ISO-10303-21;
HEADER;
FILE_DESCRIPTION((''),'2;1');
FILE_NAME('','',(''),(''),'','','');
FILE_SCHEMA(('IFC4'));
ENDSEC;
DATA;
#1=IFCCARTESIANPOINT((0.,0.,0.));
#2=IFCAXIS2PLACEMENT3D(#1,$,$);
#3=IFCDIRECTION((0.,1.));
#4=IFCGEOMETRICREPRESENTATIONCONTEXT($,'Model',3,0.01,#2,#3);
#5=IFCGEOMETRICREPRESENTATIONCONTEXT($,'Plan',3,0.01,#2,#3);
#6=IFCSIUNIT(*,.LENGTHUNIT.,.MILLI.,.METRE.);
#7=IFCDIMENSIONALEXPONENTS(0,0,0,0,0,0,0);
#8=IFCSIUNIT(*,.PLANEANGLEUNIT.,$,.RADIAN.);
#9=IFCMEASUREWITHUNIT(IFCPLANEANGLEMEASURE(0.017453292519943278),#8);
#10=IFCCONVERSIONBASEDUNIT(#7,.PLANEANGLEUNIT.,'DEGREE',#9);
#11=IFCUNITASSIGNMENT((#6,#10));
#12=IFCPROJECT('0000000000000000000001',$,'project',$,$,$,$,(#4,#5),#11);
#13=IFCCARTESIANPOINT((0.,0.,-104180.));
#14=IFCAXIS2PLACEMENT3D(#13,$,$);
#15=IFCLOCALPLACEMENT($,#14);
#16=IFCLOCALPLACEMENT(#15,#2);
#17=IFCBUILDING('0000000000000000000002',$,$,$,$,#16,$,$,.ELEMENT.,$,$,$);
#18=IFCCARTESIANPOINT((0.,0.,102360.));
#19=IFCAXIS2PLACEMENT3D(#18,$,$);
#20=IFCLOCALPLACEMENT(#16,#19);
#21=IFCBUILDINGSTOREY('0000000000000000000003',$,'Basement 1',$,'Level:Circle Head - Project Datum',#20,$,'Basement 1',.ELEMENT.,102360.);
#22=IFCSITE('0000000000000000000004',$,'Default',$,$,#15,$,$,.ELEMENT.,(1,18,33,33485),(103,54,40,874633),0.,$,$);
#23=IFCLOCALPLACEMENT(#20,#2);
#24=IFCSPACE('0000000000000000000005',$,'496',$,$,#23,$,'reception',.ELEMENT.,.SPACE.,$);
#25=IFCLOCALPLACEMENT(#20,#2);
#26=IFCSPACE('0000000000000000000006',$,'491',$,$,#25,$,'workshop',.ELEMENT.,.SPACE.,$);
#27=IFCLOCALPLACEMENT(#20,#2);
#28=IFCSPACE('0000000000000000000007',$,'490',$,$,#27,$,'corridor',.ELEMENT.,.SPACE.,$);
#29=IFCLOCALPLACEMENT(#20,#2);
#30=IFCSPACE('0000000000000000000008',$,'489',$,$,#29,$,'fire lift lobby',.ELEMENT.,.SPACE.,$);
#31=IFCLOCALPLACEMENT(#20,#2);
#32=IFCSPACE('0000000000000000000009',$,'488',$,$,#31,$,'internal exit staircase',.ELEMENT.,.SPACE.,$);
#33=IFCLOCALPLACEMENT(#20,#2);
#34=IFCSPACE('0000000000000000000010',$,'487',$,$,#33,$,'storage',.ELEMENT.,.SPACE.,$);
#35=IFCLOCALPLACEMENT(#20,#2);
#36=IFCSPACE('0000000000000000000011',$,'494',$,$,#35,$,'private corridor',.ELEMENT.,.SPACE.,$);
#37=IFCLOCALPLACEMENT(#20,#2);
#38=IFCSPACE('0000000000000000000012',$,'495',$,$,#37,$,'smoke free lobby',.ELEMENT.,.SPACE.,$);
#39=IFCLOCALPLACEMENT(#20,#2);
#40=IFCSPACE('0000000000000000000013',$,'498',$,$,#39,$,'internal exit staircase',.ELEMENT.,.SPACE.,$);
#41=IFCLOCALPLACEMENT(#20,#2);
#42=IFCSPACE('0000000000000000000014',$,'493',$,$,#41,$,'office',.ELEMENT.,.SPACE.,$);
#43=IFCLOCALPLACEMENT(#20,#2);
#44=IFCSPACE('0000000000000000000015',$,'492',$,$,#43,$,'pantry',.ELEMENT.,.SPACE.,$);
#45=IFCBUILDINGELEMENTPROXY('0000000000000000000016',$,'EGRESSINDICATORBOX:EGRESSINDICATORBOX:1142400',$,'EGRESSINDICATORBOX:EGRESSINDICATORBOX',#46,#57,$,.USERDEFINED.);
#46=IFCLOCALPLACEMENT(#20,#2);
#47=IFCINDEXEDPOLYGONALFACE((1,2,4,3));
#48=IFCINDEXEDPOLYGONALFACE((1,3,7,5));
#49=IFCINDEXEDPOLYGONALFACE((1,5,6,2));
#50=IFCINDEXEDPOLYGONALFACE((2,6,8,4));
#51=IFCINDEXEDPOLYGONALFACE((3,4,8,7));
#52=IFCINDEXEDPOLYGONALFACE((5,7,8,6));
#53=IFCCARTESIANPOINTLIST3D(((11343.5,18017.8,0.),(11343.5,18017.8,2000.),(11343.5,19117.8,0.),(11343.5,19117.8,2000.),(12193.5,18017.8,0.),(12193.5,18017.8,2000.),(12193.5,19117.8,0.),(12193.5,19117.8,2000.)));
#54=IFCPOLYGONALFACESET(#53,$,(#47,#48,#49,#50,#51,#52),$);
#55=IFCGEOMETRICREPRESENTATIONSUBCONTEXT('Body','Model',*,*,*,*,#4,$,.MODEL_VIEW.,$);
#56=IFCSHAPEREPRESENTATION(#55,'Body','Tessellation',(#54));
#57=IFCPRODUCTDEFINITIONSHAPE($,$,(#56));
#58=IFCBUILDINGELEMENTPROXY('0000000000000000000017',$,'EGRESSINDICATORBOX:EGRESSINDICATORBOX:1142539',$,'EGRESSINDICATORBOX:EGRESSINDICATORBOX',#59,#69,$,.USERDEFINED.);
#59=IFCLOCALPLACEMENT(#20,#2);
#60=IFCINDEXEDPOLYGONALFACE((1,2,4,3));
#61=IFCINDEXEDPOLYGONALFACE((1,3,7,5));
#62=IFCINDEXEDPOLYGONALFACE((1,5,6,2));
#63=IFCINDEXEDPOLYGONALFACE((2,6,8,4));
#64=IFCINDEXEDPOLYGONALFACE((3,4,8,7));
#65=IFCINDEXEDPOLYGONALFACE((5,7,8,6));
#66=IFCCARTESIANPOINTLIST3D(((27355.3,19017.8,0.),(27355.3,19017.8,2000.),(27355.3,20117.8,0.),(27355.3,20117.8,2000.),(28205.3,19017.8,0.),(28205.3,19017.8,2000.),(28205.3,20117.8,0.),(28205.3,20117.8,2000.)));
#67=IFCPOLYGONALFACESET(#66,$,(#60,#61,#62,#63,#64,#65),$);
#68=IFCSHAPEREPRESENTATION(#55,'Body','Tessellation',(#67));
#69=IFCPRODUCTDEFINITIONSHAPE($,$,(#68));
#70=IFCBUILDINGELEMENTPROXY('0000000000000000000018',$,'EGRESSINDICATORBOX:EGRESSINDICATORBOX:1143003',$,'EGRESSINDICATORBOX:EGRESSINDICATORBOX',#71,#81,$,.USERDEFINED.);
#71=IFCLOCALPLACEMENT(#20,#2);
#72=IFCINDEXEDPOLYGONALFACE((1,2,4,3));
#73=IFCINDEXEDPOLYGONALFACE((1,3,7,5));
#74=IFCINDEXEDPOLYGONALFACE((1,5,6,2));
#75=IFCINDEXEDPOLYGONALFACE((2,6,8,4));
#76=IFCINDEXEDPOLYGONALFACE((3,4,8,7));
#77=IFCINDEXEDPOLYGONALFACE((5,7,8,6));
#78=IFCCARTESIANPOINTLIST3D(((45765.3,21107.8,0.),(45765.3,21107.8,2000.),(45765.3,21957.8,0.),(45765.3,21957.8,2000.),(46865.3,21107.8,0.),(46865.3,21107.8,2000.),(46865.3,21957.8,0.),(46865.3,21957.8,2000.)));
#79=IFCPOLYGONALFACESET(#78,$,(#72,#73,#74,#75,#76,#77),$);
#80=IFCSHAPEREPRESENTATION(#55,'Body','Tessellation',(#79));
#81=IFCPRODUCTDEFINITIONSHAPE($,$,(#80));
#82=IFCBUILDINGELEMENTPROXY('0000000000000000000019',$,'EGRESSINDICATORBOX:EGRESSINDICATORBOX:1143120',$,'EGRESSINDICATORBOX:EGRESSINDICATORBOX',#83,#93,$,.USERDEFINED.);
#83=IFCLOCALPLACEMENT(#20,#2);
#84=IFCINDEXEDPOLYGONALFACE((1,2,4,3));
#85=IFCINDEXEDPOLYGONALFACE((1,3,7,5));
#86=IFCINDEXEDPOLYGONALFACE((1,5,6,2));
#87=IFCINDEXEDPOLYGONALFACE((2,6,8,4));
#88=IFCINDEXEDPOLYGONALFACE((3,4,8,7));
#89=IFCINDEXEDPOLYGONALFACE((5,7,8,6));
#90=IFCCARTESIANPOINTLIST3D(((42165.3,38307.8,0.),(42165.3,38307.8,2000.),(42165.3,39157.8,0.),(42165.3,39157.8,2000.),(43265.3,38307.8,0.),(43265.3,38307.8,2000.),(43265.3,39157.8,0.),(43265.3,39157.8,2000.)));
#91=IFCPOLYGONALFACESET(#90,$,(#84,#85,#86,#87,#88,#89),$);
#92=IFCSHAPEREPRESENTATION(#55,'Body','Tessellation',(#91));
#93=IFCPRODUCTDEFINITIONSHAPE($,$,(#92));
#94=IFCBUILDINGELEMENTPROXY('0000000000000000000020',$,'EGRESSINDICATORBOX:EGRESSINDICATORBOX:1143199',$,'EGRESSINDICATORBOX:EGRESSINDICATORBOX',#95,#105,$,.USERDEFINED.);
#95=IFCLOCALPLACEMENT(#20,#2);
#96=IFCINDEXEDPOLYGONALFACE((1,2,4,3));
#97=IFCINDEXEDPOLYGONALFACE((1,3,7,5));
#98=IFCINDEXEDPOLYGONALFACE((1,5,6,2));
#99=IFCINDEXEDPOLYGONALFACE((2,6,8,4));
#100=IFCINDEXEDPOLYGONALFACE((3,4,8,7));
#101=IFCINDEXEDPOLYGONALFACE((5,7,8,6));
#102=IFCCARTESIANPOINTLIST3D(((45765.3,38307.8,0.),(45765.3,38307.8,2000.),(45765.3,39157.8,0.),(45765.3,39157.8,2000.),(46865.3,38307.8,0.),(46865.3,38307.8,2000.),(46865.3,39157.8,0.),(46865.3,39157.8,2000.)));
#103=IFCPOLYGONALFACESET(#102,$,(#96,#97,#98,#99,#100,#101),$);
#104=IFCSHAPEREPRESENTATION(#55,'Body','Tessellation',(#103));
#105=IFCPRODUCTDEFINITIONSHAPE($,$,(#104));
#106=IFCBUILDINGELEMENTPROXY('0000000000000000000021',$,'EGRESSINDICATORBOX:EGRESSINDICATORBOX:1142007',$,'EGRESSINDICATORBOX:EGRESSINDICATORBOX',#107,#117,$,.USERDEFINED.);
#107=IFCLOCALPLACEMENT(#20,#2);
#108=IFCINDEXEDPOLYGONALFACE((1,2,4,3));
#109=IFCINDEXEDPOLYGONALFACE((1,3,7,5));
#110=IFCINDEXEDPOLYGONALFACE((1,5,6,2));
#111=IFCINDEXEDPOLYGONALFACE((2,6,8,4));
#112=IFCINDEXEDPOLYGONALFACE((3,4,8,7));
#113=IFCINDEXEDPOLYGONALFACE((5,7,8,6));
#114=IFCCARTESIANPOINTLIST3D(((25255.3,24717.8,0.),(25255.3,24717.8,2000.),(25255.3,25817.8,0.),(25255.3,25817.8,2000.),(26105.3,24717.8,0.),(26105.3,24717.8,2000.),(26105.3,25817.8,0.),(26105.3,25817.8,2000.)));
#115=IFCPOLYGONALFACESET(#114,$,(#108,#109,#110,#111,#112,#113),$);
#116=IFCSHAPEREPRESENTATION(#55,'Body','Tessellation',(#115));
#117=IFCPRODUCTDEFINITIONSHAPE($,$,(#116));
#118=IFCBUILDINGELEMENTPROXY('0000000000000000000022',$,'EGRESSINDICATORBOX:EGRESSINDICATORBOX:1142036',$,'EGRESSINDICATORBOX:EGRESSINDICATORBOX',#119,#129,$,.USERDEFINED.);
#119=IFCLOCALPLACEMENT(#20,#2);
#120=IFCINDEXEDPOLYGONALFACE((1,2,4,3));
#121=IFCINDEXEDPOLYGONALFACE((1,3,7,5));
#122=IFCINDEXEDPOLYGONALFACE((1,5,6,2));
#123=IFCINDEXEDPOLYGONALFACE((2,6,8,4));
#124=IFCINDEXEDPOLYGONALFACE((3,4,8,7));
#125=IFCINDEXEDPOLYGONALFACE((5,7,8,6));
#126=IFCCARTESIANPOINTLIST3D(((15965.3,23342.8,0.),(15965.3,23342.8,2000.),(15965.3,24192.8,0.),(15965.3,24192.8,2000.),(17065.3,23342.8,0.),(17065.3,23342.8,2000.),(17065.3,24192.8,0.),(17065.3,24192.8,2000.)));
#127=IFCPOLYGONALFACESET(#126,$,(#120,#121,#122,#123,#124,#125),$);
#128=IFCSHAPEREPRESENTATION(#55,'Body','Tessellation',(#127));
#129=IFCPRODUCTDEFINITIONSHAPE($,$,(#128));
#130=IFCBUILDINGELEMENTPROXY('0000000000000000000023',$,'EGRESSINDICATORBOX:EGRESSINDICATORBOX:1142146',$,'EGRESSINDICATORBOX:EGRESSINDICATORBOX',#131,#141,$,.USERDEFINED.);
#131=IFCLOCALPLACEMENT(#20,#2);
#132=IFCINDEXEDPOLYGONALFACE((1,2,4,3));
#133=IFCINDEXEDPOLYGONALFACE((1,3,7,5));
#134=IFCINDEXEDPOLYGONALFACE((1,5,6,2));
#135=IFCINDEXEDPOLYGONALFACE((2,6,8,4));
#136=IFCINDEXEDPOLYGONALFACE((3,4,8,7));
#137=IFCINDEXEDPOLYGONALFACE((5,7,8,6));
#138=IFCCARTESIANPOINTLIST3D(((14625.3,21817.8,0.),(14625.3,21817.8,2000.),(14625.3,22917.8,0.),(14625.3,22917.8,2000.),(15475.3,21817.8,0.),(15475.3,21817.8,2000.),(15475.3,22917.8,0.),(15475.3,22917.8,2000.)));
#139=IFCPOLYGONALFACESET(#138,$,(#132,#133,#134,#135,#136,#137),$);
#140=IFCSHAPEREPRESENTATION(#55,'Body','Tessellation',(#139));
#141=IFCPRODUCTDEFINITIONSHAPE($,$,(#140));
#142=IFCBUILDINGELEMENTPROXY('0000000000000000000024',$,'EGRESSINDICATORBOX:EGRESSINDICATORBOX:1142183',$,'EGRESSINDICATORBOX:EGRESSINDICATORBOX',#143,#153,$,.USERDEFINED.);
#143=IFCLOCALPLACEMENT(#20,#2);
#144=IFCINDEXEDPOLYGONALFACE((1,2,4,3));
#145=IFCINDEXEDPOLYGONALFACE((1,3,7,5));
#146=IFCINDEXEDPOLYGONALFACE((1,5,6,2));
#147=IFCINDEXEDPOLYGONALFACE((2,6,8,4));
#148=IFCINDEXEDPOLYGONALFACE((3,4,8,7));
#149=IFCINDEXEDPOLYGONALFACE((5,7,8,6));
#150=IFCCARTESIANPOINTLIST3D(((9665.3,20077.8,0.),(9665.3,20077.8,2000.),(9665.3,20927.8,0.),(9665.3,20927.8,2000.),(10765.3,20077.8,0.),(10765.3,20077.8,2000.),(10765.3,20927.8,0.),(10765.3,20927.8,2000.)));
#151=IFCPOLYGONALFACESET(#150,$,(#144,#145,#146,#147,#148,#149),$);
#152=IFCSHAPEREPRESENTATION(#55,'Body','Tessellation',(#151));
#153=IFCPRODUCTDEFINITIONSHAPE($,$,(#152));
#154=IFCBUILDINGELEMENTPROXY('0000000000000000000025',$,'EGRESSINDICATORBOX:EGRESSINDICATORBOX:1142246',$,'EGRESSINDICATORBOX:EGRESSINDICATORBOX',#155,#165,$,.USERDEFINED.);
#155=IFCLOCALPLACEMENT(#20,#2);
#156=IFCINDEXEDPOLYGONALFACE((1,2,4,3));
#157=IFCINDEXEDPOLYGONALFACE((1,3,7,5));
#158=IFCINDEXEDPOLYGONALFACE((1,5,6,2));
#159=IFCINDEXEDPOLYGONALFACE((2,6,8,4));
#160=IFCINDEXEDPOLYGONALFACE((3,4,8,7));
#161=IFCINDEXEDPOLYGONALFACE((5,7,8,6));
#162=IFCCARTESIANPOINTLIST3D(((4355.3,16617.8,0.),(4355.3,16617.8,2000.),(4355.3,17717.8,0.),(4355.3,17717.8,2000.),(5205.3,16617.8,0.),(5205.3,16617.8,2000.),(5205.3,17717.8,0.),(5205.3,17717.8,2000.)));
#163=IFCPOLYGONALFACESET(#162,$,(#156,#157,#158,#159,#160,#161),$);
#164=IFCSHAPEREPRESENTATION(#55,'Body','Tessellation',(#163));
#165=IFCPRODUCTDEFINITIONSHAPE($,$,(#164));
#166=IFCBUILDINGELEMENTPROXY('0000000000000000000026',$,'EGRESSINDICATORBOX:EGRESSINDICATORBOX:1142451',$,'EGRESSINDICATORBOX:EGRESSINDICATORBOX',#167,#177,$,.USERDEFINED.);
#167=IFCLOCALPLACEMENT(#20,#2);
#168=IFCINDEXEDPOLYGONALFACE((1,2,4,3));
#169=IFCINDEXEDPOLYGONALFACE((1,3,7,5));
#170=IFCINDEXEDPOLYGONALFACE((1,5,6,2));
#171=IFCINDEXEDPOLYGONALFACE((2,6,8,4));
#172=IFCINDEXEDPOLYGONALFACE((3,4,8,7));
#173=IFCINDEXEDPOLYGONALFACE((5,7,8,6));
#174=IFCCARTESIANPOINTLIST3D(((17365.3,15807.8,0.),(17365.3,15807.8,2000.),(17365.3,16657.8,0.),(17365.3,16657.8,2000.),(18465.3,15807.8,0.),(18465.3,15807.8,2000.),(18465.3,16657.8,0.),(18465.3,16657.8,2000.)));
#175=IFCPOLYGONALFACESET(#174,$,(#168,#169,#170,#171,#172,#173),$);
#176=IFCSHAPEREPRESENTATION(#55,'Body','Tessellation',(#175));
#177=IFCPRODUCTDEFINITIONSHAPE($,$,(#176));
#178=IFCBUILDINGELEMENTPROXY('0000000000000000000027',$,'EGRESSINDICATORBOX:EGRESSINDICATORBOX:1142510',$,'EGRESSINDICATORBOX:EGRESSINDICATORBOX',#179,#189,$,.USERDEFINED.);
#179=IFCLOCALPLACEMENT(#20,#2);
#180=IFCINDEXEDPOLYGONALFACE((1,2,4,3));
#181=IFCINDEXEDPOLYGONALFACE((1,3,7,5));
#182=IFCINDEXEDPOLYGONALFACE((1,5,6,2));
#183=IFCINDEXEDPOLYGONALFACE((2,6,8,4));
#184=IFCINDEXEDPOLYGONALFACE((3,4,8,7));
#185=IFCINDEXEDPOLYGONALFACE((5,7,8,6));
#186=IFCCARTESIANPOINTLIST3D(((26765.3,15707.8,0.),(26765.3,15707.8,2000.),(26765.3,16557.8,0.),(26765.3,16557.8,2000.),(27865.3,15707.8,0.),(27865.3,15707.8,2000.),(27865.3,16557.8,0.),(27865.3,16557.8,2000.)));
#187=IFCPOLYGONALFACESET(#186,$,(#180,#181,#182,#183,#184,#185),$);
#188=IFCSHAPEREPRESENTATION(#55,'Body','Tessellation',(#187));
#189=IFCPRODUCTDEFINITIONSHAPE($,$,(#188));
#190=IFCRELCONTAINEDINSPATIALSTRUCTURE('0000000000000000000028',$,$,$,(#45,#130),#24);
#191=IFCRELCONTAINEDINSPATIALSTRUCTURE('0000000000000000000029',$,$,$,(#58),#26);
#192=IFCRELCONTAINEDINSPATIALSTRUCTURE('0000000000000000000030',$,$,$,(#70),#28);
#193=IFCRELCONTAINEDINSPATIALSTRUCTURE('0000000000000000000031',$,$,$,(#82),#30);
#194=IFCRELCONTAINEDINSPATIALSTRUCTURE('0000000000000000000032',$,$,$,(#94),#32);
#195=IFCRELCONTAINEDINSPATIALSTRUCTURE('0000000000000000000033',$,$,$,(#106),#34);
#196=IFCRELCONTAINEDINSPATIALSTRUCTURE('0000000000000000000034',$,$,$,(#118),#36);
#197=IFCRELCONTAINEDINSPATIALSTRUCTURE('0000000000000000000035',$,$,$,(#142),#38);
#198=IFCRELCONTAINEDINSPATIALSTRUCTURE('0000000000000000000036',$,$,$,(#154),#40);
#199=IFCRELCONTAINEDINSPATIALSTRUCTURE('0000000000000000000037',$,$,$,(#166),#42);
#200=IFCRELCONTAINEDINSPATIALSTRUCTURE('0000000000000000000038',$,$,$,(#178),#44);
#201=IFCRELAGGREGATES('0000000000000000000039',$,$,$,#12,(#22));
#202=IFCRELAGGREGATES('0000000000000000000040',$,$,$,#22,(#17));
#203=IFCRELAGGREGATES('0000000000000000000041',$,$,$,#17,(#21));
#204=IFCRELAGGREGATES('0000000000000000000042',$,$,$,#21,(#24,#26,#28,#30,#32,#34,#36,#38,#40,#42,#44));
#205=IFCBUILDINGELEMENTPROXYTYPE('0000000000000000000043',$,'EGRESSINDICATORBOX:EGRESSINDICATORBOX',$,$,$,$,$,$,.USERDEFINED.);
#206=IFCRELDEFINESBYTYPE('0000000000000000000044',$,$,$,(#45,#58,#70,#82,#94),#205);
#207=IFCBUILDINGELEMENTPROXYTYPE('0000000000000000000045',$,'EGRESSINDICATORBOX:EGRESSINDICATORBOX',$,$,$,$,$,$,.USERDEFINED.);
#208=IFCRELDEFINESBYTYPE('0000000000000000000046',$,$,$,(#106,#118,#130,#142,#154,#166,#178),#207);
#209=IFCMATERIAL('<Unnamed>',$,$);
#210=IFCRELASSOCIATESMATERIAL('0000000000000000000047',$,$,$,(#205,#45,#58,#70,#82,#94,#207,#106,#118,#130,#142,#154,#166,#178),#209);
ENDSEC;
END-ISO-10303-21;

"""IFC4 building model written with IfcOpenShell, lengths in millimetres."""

from ifc_helpers import new_model, entity, si_unit, converted_unit, direction, frame, origin, place, context, subcontext, project, spatial, indexed_curve, outline, extrude, source, transform, mapped, material, type_object, type_shapes, element, save


model = new_model("IFC4")

# Units and contexts
model_context = context("Model", 3, precision=0.01, world=origin(), true_north=direction((0.0, 1.0)))
plan_context = context("Plan", 3, precision=0.01, world=origin(), true_north=direction((0.0, 1.0)))
body_context = subcontext(model_context, "Body", "Model", "MODEL_VIEW")
ifc_project = project(units=[si_unit("LENGTHUNIT", "METRE", prefix="MILLI"), converted_unit("PLANEANGLEUNIT", "DEGREE", entity("IfcPlaneAngleMeasure", 0.017453292519943278), si_unit("PLANEANGLEUNIT", "RADIAN"), dimensions=[0, 0, 0, 0, 0, 0, 0])], contexts=[model_context, plan_context])

# Site, building, storey
site_placement = place(None, frame((0.0, 0.0, -104180.0)))
site = spatial("IfcSite", under=ifc_project, at=site_placement, Name="Default", CompositionType="ELEMENT", RefLatitude=(1, 18, 33, 33485), RefLongitude=(103, 54, 40, 874633), RefElevation=0.0)
building_placement = place(site_placement, origin())
building = spatial("IfcBuilding", under=site, at=building_placement, CompositionType="ELEMENT")
storey_placement = place(building_placement, frame((0.0, 0.0, 102360.0)))
storey = spatial("IfcBuildingStorey", under=building, at=storey_placement, Name="Basement 1", ObjectType="Level:Circle Head - Project Datum", LongName="Basement 1", CompositionType="ELEMENT", Elevation=102360.0)

# Shared definitions
ifc_material_1 = material(Name="<Unnamed>")
building_element_proxy_type_1 = type_object("IfcBuildingElementProxyType", Name="EGRESSINDICATORBOX:EGRESSINDICATORBOX", PredefinedType="USERDEFINED", material=ifc_material_1)
shared_shape_1 = source(origin(), body_context, "Body", "SweptSolid", [
    extrude(outline(indexed_curve([(-550.0, -425.0), (550.0, -425.0), (550.0, 425.0), (-550.0, 425.0), (-550.0, -425.0)], self_intersect=False)), frame((0.0, 0.0, 0.0), z_axis=(0.0, 0.0, 1.0), x_axis=(0.0, 1.0, 0.0)), (0.0, 0.0, 1.0), 2000.0),
])
type_shapes(building_element_proxy_type_1, [shared_shape_1])

# Shared definitions
space_1_placement = place(storey_placement, origin())
space_1 = spatial("IfcSpace", under=storey, at=space_1_placement, Name="496", LongName="reception", CompositionType="ELEMENT", PredefinedType="SPACE")

# Building element proxy
proxy_1_placement = place(space_1_placement, frame((11768.5, 18567.8, 0.0), z_axis=(0.0, 0.0, 1.0), x_axis=(-1.0, 0.0, 0.0)))
element("IfcBuildingElementProxy", 1, at=proxy_1_placement, inside=space_1, type_object=building_element_proxy_type_1, material=ifc_material_1, Name="EGRESSINDICATORBOX:EGRESSINDICATORBOX:1142400", ObjectType="EGRESSINDICATORBOX:EGRESSINDICATORBOX", PredefinedType="USERDEFINED", context=body_context, shape_type="MappedRepresentation", body=[
    mapped(shared_shape_1, transform((0.0, 0.0, 0.0), scale=1.0)),
])

# Shared definitions
space_2_placement = place(storey_placement, origin())
space_2 = spatial("IfcSpace", under=storey, at=space_2_placement, Name="491", LongName="workshop", CompositionType="ELEMENT", PredefinedType="SPACE")

# Building element proxy
proxy_2_placement = place(space_2_placement, frame((27780.3, 19567.8, 0.0), z_axis=(0.0, 0.0, 1.0), x_axis=(-1.0, 0.0, 0.0)))
element("IfcBuildingElementProxy", 2, at=proxy_2_placement, inside=space_2, type_object=building_element_proxy_type_1, material=ifc_material_1, Name="EGRESSINDICATORBOX:EGRESSINDICATORBOX:1142539", ObjectType="EGRESSINDICATORBOX:EGRESSINDICATORBOX", PredefinedType="USERDEFINED", context=body_context, shape_type="MappedRepresentation", body=[
    mapped(shared_shape_1, transform((0.0, 0.0, 0.0), scale=1.0)),
])

# Shared definitions
space_3_placement = place(storey_placement, origin())
space_3 = spatial("IfcSpace", under=storey, at=space_3_placement, Name="490", LongName="corridor", CompositionType="ELEMENT", PredefinedType="SPACE")

# Building element proxy
proxy_3_placement = place(space_3_placement, frame((46315.3, 21532.8, 0.0), z_axis=(0.0, 0.0, 1.0), x_axis=(0.0, 1.0, 0.0)))
element("IfcBuildingElementProxy", 3, at=proxy_3_placement, inside=space_3, type_object=building_element_proxy_type_1, material=ifc_material_1, Name="EGRESSINDICATORBOX:EGRESSINDICATORBOX:1143003", ObjectType="EGRESSINDICATORBOX:EGRESSINDICATORBOX", PredefinedType="USERDEFINED", context=body_context, shape_type="MappedRepresentation", body=[
    mapped(shared_shape_1, transform((0.0, 0.0, 0.0), scale=1.0)),
])

# Shared definitions
space_4_placement = place(storey_placement, origin())
space_4 = spatial("IfcSpace", under=storey, at=space_4_placement, Name="489", LongName="fire lift lobby", CompositionType="ELEMENT", PredefinedType="SPACE")

# Building element proxy
proxy_4_placement = place(space_4_placement, frame((42715.3, 38732.8, 0.0), z_axis=(0.0, 0.0, 1.0), x_axis=(0.0, 1.0, 0.0)))
element("IfcBuildingElementProxy", 4, at=proxy_4_placement, inside=space_4, type_object=building_element_proxy_type_1, material=ifc_material_1, Name="EGRESSINDICATORBOX:EGRESSINDICATORBOX:1143120", ObjectType="EGRESSINDICATORBOX:EGRESSINDICATORBOX", PredefinedType="USERDEFINED", context=body_context, shape_type="MappedRepresentation", body=[
    mapped(shared_shape_1, transform((0.0, 0.0, 0.0), scale=1.0)),
])

# Shared definitions
space_5_placement = place(storey_placement, origin())
space_5 = spatial("IfcSpace", under=storey, at=space_5_placement, Name="488", LongName="internal exit staircase", CompositionType="ELEMENT", PredefinedType="SPACE")

# Building element proxy
proxy_5_placement = place(space_5_placement, frame((46315.3, 38732.8, 0.0), z_axis=(0.0, 0.0, 1.0), x_axis=(0.0, 1.0, 0.0)))
element("IfcBuildingElementProxy", 5, at=proxy_5_placement, inside=space_5, type_object=building_element_proxy_type_1, material=ifc_material_1, Name="EGRESSINDICATORBOX:EGRESSINDICATORBOX:1143199", ObjectType="EGRESSINDICATORBOX:EGRESSINDICATORBOX", PredefinedType="USERDEFINED", context=body_context, shape_type="MappedRepresentation", body=[
    mapped(shared_shape_1, transform((0.0, 0.0, 0.0), scale=1.0)),
])

# Shared definitions
space_6_placement = place(storey_placement, origin())
space_6 = spatial("IfcSpace", under=storey, at=space_6_placement, Name="487", LongName="storage", CompositionType="ELEMENT", PredefinedType="SPACE")

# Building element proxy
building_element_proxy_type_2 = type_object("IfcBuildingElementProxyType", Name="EGRESSINDICATORBOX:EGRESSINDICATORBOX", PredefinedType="USERDEFINED", material=ifc_material_1)
shared_shape_2 = source(origin(), body_context, "Body", "SweptSolid", [
    extrude(outline(indexed_curve([(-425.0, -550.0), (425.0, -550.0), (425.0, 550.0), (-425.0, 550.0), (-425.0, -550.0)], self_intersect=False)), frame((0.0, 0.0, 0.0), z_axis=(0.0, 0.0, 1.0), x_axis=(-1.0, 0.0, 0.0)), (0.0, 0.0, 1.0), 2000.0),
])
type_shapes(building_element_proxy_type_2, [shared_shape_2])
proxy_6_placement = place(space_6_placement, frame((25680.3, 25267.8, 0.0)))
element("IfcBuildingElementProxy", 6, at=proxy_6_placement, inside=space_6, type_object=building_element_proxy_type_2, material=ifc_material_1, Name="EGRESSINDICATORBOX:EGRESSINDICATORBOX:1142007", ObjectType="EGRESSINDICATORBOX:EGRESSINDICATORBOX", PredefinedType="USERDEFINED", context=body_context, shape_type="MappedRepresentation", body=[
    mapped(shared_shape_2, transform((0.0, 0.0, 0.0), scale=1.0)),
])

# Shared definitions
space_7_placement = place(storey_placement, origin())
space_7 = spatial("IfcSpace", under=storey, at=space_7_placement, Name="494", LongName="private corridor", CompositionType="ELEMENT", PredefinedType="SPACE")

# Building element proxies
proxy_7_placement = place(space_7_placement, frame((16515.3, 23767.8, 0.0), z_axis=(0.0, 0.0, 1.0), x_axis=(0.0, 1.0, 0.0)))
element("IfcBuildingElementProxy", 7, at=proxy_7_placement, inside=space_7, type_object=building_element_proxy_type_2, material=ifc_material_1, Name="EGRESSINDICATORBOX:EGRESSINDICATORBOX:1142036", ObjectType="EGRESSINDICATORBOX:EGRESSINDICATORBOX", PredefinedType="USERDEFINED", context=body_context, shape_type="MappedRepresentation", body=[
    mapped(shared_shape_2, transform((0.0, 0.0, 0.0), scale=1.0)),
])
proxy_8_placement = place(space_1_placement, frame((15050.3, 22367.8, 0.0), z_axis=(0.0, 0.0, 1.0), x_axis=(-1.0, 0.0, 0.0)))
element("IfcBuildingElementProxy", 8, at=proxy_8_placement, inside=space_1, type_object=building_element_proxy_type_2, material=ifc_material_1, Name="EGRESSINDICATORBOX:EGRESSINDICATORBOX:1142146", ObjectType="EGRESSINDICATORBOX:EGRESSINDICATORBOX", PredefinedType="USERDEFINED", context=body_context, shape_type="MappedRepresentation", body=[
    mapped(shared_shape_2, transform((0.0, 0.0, 0.0), scale=1.0)),
])

# Shared definitions
space_8_placement = place(storey_placement, origin())
space_8 = spatial("IfcSpace", under=storey, at=space_8_placement, Name="495", LongName="smoke free lobby", CompositionType="ELEMENT", PredefinedType="SPACE")

# Building element proxy
proxy_9_placement = place(space_8_placement, frame((10215.3, 20502.8, 0.0), z_axis=(0.0, 0.0, 1.0), x_axis=(0.0, 1.0, 0.0)))
element("IfcBuildingElementProxy", 9, at=proxy_9_placement, inside=space_8, type_object=building_element_proxy_type_2, material=ifc_material_1, Name="EGRESSINDICATORBOX:EGRESSINDICATORBOX:1142183", ObjectType="EGRESSINDICATORBOX:EGRESSINDICATORBOX", PredefinedType="USERDEFINED", context=body_context, shape_type="MappedRepresentation", body=[
    mapped(shared_shape_2, transform((0.0, 0.0, 0.0), scale=1.0)),
])

# Shared definitions
space_9_placement = place(storey_placement, origin())
space_9 = spatial("IfcSpace", under=storey, at=space_9_placement, Name="498", LongName="internal exit staircase", CompositionType="ELEMENT", PredefinedType="SPACE")

# Building element proxy
proxy_10_placement = place(space_9_placement, frame((4780.3, 17167.8, 0.0), z_axis=(0.0, 0.0, 1.0), x_axis=(-1.0, 0.0, 0.0)))
element("IfcBuildingElementProxy", 10, at=proxy_10_placement, inside=space_9, type_object=building_element_proxy_type_2, material=ifc_material_1, Name="EGRESSINDICATORBOX:EGRESSINDICATORBOX:1142246", ObjectType="EGRESSINDICATORBOX:EGRESSINDICATORBOX", PredefinedType="USERDEFINED", context=body_context, shape_type="MappedRepresentation", body=[
    mapped(shared_shape_2, transform((0.0, 0.0, 0.0), scale=1.0)),
])

# Shared definitions
space_10_placement = place(storey_placement, origin())
space_10 = spatial("IfcSpace", under=storey, at=space_10_placement, Name="493", LongName="office", CompositionType="ELEMENT", PredefinedType="SPACE")

# Building element proxy
proxy_11_placement = place(space_10_placement, frame((17915.3, 16232.8, 0.0), z_axis=(0.0, 0.0, 1.0), x_axis=(0.0, -1.0, 0.0)))
element("IfcBuildingElementProxy", 11, at=proxy_11_placement, inside=space_10, type_object=building_element_proxy_type_2, material=ifc_material_1, Name="EGRESSINDICATORBOX:EGRESSINDICATORBOX:1142451", ObjectType="EGRESSINDICATORBOX:EGRESSINDICATORBOX", PredefinedType="USERDEFINED", context=body_context, shape_type="MappedRepresentation", body=[
    mapped(shared_shape_2, transform((0.0, 0.0, 0.0), scale=1.0)),
])

# Shared definitions
space_11_placement = place(storey_placement, origin())
space_11 = spatial("IfcSpace", under=storey, at=space_11_placement, Name="492", LongName="pantry", CompositionType="ELEMENT", PredefinedType="SPACE")

# Building element proxy
proxy_12_placement = place(space_11_placement, frame((27315.3, 16132.8, 0.0), z_axis=(0.0, 0.0, 1.0), x_axis=(0.0, -1.0, 0.0)))
element("IfcBuildingElementProxy", 12, at=proxy_12_placement, inside=space_11, type_object=building_element_proxy_type_2, material=ifc_material_1, Name="EGRESSINDICATORBOX:EGRESSINDICATORBOX:1142510", ObjectType="EGRESSINDICATORBOX:EGRESSINDICATORBOX", PredefinedType="USERDEFINED", context=body_context, shape_type="MappedRepresentation", body=[
    mapped(shared_shape_2, transform((0.0, 0.0, 0.0), scale=1.0)),
])

save(model, "model.ifc")
